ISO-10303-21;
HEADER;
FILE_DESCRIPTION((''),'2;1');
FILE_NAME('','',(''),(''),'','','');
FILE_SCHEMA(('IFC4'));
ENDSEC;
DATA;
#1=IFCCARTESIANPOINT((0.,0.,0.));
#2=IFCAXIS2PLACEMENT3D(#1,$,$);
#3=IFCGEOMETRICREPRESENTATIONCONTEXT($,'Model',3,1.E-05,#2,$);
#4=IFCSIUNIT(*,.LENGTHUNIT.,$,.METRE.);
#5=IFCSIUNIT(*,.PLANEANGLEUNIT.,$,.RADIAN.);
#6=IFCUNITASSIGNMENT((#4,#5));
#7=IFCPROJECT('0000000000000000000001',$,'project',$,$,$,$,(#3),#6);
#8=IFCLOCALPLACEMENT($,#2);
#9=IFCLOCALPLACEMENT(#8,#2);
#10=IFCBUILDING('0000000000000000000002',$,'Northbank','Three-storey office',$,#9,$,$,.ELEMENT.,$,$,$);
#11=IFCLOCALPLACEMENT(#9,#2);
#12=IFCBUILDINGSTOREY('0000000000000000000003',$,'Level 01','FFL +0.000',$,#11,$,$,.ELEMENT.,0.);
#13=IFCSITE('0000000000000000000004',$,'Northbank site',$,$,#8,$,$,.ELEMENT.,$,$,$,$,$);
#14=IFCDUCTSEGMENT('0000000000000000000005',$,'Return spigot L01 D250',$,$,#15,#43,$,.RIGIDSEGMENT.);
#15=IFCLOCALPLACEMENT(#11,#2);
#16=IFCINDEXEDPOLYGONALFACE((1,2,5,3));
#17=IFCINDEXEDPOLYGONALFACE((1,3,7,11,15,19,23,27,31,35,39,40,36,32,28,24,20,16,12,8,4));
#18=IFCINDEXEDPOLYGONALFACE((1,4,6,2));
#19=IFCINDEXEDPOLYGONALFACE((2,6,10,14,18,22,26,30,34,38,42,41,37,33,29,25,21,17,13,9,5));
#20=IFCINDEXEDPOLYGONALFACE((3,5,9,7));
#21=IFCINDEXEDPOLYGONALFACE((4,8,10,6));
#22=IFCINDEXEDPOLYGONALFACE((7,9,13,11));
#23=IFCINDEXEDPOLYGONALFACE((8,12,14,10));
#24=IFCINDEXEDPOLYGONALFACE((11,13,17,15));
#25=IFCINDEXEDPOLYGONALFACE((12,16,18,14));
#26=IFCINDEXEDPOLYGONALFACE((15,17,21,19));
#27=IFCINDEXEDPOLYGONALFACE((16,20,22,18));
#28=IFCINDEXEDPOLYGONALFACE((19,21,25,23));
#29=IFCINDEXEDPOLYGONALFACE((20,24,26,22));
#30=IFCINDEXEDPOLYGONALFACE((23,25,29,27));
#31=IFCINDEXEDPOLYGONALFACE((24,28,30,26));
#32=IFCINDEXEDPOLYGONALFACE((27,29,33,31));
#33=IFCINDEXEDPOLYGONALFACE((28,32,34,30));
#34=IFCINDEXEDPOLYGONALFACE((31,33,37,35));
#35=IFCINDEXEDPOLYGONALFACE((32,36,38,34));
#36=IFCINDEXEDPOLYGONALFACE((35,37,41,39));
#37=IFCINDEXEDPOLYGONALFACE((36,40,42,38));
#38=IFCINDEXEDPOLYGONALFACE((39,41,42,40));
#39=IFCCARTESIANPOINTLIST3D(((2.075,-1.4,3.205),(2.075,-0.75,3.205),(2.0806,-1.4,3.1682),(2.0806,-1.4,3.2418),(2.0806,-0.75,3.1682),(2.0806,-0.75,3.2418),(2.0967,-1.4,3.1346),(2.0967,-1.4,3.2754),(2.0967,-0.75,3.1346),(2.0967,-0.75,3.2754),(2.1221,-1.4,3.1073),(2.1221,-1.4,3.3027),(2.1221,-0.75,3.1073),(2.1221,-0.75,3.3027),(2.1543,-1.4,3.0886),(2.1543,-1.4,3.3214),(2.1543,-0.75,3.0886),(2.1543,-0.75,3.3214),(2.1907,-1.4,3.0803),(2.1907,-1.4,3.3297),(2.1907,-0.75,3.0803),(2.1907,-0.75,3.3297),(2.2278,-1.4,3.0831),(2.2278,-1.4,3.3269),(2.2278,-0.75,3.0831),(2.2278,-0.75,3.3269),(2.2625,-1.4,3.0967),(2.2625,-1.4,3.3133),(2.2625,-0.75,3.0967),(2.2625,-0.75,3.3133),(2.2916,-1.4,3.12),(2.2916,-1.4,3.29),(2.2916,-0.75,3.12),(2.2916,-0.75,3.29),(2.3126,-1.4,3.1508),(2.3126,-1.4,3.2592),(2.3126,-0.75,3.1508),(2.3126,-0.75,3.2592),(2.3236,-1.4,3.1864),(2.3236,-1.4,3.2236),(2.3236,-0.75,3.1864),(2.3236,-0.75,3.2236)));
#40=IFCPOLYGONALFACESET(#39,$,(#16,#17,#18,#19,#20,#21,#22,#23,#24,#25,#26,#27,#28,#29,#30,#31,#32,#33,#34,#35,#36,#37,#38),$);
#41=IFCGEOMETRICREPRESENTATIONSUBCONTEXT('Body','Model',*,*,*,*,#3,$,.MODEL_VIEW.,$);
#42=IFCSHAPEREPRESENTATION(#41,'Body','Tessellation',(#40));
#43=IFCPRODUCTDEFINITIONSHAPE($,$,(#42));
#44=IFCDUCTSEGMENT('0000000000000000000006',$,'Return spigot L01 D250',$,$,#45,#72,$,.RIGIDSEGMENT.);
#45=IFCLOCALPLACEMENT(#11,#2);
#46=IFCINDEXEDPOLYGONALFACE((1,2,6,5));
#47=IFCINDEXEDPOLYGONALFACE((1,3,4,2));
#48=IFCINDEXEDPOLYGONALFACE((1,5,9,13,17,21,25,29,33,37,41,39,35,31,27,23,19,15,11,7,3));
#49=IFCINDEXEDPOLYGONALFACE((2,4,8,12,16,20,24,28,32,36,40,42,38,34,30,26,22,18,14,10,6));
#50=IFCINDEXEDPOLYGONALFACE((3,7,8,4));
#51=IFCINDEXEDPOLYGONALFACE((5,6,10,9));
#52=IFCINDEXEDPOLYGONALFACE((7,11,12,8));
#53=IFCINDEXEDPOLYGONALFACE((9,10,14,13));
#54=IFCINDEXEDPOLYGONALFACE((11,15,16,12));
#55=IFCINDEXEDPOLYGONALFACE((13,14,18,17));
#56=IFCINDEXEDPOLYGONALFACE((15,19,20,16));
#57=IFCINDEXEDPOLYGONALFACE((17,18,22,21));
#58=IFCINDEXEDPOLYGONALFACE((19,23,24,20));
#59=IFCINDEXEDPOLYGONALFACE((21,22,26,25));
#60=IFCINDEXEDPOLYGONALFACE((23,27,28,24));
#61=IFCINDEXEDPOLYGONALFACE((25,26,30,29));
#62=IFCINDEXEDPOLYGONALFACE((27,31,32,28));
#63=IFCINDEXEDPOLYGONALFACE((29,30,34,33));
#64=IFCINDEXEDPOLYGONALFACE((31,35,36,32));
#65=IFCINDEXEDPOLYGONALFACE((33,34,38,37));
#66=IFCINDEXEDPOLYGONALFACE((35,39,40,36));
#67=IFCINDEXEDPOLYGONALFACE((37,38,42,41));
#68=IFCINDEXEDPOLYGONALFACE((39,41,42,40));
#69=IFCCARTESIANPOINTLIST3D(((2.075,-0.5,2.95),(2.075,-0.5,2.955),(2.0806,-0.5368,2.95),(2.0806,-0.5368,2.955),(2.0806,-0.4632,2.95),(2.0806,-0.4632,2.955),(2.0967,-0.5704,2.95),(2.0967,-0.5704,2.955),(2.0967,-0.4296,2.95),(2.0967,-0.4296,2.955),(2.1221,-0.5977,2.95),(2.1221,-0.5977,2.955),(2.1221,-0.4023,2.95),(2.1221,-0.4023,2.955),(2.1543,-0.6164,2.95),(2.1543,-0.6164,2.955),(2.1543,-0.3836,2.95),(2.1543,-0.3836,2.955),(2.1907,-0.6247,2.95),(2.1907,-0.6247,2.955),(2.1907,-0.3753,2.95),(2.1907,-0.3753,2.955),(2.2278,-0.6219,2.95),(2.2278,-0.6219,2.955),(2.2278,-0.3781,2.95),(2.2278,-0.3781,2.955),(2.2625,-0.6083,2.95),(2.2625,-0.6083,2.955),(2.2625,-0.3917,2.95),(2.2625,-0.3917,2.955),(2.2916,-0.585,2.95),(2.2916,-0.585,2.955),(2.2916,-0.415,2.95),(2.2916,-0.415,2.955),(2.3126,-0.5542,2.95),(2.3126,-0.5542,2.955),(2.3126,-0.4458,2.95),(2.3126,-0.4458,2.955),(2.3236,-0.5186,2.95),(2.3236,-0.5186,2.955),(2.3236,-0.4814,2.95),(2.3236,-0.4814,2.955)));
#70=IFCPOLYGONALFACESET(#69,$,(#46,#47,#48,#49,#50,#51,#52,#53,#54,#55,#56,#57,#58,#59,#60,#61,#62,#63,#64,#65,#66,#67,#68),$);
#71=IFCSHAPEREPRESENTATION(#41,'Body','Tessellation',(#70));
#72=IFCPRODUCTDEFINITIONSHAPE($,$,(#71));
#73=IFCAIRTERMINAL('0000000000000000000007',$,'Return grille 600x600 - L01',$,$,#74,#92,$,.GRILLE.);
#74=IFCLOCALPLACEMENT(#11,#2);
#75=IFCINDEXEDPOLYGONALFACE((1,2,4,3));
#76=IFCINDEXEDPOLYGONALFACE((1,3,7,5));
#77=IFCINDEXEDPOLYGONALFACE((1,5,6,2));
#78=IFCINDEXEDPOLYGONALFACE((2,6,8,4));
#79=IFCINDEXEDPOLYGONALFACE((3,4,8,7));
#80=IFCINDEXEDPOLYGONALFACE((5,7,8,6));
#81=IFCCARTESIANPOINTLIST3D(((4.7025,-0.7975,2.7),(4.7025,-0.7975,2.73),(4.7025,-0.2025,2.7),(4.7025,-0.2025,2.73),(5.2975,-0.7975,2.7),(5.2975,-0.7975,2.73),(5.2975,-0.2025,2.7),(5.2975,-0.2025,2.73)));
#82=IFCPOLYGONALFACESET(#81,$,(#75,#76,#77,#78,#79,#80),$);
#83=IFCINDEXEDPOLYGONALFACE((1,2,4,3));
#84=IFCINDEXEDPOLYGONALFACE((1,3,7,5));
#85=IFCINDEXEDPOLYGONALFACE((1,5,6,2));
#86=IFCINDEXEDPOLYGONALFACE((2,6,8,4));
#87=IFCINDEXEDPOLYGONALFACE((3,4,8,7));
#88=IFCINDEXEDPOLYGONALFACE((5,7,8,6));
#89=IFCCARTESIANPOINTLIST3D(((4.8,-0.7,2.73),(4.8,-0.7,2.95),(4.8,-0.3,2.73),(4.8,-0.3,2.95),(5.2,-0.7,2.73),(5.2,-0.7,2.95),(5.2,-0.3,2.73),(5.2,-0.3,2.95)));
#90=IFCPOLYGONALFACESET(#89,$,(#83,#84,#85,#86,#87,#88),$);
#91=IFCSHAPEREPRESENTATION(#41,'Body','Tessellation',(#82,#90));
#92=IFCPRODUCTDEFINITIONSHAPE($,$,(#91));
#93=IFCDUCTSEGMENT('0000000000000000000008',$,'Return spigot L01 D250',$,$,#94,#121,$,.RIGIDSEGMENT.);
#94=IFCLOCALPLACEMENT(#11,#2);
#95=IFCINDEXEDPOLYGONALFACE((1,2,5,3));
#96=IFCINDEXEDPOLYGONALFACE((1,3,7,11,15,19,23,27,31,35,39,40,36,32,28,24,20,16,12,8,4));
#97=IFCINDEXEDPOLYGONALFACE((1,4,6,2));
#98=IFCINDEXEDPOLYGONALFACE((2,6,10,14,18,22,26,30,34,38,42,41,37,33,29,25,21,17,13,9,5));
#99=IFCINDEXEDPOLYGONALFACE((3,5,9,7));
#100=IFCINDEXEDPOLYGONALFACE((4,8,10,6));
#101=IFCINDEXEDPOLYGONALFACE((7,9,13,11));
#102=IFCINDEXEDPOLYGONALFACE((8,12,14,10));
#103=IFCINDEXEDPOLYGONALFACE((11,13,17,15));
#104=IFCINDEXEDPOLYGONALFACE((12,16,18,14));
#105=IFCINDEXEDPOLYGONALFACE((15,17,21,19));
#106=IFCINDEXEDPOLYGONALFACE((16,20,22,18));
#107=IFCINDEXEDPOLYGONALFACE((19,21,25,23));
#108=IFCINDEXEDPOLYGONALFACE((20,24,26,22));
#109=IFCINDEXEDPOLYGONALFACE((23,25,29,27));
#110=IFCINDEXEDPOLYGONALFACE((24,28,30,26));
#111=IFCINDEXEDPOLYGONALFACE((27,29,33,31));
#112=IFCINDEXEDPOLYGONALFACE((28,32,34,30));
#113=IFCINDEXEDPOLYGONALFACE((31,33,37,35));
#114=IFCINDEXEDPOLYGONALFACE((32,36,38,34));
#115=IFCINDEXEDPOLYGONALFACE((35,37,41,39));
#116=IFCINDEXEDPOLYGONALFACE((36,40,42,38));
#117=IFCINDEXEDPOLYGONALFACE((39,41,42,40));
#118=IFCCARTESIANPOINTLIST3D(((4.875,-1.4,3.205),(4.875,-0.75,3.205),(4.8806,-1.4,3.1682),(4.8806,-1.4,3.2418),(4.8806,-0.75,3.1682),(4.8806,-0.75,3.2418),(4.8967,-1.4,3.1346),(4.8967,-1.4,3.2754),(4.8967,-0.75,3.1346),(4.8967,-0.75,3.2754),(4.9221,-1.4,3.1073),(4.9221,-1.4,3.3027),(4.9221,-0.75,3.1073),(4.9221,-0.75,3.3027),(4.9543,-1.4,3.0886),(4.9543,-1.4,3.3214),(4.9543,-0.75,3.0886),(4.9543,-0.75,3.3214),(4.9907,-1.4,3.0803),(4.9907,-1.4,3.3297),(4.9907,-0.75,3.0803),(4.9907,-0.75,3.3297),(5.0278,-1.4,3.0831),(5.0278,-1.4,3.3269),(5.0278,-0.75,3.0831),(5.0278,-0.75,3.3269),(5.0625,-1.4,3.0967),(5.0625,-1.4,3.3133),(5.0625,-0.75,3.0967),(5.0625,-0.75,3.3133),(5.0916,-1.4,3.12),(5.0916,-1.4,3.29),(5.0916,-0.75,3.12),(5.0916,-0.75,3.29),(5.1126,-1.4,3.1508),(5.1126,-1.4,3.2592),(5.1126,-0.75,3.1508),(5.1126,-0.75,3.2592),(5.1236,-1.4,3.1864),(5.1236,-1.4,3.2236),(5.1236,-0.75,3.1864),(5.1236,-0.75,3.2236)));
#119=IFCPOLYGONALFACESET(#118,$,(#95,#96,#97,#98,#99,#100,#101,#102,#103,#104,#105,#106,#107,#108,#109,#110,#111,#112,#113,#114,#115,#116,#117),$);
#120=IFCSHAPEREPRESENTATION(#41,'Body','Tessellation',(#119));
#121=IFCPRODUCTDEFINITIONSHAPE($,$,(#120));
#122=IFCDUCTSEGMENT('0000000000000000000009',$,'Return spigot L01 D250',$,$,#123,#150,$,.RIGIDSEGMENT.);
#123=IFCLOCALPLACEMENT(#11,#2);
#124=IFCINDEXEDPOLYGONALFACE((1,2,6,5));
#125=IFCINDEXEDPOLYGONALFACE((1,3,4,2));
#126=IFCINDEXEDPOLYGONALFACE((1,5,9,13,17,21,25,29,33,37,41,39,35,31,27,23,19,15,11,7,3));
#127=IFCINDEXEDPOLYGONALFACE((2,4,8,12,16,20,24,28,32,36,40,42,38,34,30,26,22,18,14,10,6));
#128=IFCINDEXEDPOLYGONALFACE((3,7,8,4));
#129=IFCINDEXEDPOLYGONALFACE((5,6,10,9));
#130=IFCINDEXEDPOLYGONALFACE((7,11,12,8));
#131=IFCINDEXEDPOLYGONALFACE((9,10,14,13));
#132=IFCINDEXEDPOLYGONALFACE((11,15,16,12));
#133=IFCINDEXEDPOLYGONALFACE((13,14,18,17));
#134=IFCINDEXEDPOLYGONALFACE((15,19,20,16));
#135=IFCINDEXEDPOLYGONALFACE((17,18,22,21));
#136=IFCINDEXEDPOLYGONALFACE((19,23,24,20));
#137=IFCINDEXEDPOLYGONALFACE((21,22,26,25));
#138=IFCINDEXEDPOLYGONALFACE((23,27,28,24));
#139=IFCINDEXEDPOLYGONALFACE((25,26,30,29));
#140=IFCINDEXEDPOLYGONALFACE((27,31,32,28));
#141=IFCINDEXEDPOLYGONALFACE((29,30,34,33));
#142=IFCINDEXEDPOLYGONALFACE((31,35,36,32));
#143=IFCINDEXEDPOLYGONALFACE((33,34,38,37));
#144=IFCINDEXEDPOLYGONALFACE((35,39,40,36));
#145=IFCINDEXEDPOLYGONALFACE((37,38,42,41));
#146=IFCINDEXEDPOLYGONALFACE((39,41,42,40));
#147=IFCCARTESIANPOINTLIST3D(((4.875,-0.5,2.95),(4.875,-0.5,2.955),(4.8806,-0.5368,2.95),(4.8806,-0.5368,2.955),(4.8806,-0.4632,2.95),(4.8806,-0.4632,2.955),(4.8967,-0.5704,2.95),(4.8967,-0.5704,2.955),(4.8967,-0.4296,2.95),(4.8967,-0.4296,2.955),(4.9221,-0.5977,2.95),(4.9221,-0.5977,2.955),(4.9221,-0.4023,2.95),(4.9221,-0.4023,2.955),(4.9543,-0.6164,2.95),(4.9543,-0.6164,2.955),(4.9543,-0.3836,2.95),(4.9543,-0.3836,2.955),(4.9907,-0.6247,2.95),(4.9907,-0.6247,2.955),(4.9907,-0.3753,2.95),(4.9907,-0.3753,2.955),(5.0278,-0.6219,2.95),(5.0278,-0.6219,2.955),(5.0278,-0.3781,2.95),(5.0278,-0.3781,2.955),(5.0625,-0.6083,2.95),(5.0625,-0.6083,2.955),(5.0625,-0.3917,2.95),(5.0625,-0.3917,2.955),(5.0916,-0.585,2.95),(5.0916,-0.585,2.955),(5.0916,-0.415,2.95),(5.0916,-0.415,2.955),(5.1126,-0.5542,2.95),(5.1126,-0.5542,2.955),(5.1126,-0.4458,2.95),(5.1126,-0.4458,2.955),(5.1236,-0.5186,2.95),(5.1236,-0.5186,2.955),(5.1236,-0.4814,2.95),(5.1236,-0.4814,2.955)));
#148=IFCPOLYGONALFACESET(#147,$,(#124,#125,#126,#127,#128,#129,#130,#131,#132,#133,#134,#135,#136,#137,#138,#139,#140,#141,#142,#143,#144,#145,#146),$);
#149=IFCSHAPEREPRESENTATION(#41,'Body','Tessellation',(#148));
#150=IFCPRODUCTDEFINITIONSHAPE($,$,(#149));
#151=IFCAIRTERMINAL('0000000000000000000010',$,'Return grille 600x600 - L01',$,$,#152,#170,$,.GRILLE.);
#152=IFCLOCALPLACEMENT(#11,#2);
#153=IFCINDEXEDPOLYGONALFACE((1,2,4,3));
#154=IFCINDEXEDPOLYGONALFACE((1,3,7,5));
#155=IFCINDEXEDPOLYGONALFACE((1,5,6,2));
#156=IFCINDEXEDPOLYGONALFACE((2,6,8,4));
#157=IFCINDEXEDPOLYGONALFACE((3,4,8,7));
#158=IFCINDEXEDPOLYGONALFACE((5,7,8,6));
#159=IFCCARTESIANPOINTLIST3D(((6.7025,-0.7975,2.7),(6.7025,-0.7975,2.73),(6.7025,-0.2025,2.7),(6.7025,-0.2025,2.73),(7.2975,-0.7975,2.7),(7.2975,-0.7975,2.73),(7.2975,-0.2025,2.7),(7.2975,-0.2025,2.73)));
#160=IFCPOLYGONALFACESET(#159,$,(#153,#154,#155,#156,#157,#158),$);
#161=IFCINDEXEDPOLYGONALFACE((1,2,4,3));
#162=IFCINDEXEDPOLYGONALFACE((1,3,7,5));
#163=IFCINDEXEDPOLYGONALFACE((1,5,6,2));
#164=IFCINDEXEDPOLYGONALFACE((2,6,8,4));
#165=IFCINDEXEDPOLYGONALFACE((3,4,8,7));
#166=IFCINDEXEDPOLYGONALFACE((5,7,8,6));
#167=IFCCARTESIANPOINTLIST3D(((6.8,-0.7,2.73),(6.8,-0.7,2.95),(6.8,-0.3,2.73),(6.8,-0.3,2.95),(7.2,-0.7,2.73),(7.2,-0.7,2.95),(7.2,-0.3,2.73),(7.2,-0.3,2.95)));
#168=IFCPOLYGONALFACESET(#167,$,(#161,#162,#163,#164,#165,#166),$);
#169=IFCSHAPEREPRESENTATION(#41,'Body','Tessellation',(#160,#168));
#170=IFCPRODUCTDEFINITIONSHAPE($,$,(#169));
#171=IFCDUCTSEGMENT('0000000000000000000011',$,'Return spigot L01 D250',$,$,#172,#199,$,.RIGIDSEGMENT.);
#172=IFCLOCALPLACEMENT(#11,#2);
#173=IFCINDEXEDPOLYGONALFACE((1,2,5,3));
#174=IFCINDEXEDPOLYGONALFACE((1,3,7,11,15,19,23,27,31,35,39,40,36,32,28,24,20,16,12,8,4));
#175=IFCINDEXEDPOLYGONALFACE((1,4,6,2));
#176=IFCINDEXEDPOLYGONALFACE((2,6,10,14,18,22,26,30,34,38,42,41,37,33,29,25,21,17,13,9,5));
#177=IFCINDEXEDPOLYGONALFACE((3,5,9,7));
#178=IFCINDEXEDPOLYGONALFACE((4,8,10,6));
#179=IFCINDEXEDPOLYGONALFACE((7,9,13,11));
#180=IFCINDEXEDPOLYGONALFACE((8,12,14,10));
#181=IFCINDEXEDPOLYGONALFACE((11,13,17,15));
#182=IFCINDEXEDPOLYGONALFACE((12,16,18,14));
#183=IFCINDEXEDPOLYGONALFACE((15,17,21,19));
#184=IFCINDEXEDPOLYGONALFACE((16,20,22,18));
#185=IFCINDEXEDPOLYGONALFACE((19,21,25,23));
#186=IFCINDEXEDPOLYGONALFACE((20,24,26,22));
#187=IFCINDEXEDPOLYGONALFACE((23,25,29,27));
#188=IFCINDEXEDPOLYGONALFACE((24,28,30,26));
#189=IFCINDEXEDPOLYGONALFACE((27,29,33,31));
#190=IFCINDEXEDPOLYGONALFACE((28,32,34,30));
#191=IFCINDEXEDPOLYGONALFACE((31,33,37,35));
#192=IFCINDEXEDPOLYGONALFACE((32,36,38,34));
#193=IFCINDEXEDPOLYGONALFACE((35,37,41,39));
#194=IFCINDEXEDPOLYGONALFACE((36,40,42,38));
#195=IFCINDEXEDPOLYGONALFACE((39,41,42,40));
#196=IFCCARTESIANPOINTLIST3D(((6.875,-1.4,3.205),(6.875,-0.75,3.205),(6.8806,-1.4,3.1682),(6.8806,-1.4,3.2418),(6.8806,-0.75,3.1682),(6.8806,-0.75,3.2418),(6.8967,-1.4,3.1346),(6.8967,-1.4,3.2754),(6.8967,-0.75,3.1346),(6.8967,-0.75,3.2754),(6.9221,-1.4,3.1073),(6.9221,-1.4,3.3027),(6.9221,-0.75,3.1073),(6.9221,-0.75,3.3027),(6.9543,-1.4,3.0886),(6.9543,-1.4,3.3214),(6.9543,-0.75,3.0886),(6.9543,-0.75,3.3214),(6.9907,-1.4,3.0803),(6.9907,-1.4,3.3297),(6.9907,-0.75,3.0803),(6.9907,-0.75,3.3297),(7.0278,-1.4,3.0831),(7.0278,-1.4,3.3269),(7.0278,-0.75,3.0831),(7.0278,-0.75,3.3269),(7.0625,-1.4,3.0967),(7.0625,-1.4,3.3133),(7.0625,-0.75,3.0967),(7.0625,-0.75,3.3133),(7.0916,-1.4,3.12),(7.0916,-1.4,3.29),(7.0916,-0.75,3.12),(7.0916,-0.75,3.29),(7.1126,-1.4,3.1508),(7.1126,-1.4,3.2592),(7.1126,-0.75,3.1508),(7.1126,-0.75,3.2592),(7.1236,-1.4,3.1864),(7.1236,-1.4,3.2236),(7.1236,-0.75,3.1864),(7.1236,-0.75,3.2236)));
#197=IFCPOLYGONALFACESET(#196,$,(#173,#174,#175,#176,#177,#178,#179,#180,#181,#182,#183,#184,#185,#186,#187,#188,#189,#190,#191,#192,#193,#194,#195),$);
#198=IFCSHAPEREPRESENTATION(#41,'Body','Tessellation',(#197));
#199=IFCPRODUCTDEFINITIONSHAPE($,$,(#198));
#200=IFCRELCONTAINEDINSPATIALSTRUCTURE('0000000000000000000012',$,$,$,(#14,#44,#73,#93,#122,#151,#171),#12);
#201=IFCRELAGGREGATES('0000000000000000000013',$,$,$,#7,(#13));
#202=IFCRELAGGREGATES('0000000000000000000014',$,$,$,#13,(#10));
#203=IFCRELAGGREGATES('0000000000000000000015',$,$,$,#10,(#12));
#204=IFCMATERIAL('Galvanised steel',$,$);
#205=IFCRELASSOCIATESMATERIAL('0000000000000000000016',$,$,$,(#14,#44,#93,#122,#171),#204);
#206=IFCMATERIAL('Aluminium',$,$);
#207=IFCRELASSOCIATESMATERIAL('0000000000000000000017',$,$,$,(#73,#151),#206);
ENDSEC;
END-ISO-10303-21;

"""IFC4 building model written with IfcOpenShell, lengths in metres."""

from ifc_helpers import new_model, si_unit, frame, origin, place, context, subcontext, project, spatial, rectangle, circle, extrude, material, element, save


model = new_model("IFC4")

# Units and contexts
model_context = context("Model", 3, precision=1e-05, world=origin())
body_context = subcontext(model_context, "Body", "Model", "MODEL_VIEW")
ifc_project = project(units=[si_unit("LENGTHUNIT", "METRE"), si_unit("PLANEANGLEUNIT", "RADIAN")], contexts=[model_context])

# Site, building, storey
site_placement = place(None, origin())
site = spatial("IfcSite", under=ifc_project, at=site_placement, Name="Northbank site", CompositionType="ELEMENT")
building_placement = place(site_placement, origin())
building = spatial("IfcBuilding", under=site, at=building_placement, Name="Northbank", Description="Three-storey office", CompositionType="ELEMENT")
storey_placement = place(building_placement, origin())
storey = spatial("IfcBuildingStorey", under=building, at=storey_placement, Name="Level 01", Description="FFL +0.000", CompositionType="ELEMENT", Elevation=0.0)

# Shared definitions
ifc_material_1 = material(Name="Galvanised steel")

# Shared definitions
ifc_material_2 = material(Name="Aluminium")

# Duct segments
duct_segment_1_placement = place(storey_placement, origin())
element("IfcDuctSegment", 1, at=duct_segment_1_placement, inside=storey, material=ifc_material_1, Name="Return spigot L01 D250", PredefinedType="RIGIDSEGMENT", context=body_context, shape_type="SweptSolid", body=[
    extrude(circle(Radius=0.125), frame((2.2, -1.4, 3.205), z_axis=(0.0, 1.0, 0.0), x_axis=(-1.0, 0.0, 0.0)), (0.0, 0.0, 1.0), 0.65),
])
duct_segment_2_placement = place(storey_placement, origin())
element("IfcDuctSegment", 2, at=duct_segment_2_placement, inside=storey, material=ifc_material_1, Name="Return spigot L01 D250", PredefinedType="RIGIDSEGMENT", context=body_context, shape_type="SweptSolid", body=[
    extrude(circle(Radius=0.125), frame((2.2, -0.5, 2.955), z_axis=(0.0, 0.0, -1.0), x_axis=(-1.0, 0.0, 0.0)), (0.0, 0.0, 1.0), 0.005),
])

# Air terminal
air_terminal_1_placement = place(storey_placement, origin())
element("IfcAirTerminal", 3, at=air_terminal_1_placement, inside=storey, material=ifc_material_2, Name="Return grille 600x600 - L01", PredefinedType="GRILLE", context=body_context, shape_type="SweptSolid", body=[
    extrude(rectangle(XDim=0.595, YDim=0.595), frame((5.0, -0.5, 2.7)), (0.0, 0.0, 1.0), 0.03),
    extrude(rectangle(XDim=0.4, YDim=0.4), frame((5.0, -0.5, 2.73)), (0.0, 0.0, 1.0), 0.22),
])

# Duct segments
duct_segment_3_placement = place(storey_placement, origin())
element("IfcDuctSegment", 4, at=duct_segment_3_placement, inside=storey, material=ifc_material_1, Name="Return spigot L01 D250", PredefinedType="RIGIDSEGMENT", context=body_context, shape_type="SweptSolid", body=[
    extrude(circle(Radius=0.125), frame((5.0, -1.4, 3.205), z_axis=(0.0, 1.0, 0.0), x_axis=(-1.0, 0.0, 0.0)), (0.0, 0.0, 1.0), 0.65),
])
duct_segment_4_placement = place(storey_placement, origin())
element("IfcDuctSegment", 5, at=duct_segment_4_placement, inside=storey, material=ifc_material_1, Name="Return spigot L01 D250", PredefinedType="RIGIDSEGMENT", context=body_context, shape_type="SweptSolid", body=[
    extrude(circle(Radius=0.125), frame((5.0, -0.5, 2.955), z_axis=(0.0, 0.0, -1.0), x_axis=(-1.0, 0.0, 0.0)), (0.0, 0.0, 1.0), 0.005),
])

# Air terminal
air_terminal_2_placement = place(storey_placement, origin())
element("IfcAirTerminal", 6, at=air_terminal_2_placement, inside=storey, material=ifc_material_2, Name="Return grille 600x600 - L01", PredefinedType="GRILLE", context=body_context, shape_type="SweptSolid", body=[
    extrude(rectangle(XDim=0.595, YDim=0.595), frame((7.0, -0.5, 2.7)), (0.0, 0.0, 1.0), 0.03),
    extrude(rectangle(XDim=0.4, YDim=0.4), frame((7.0, -0.5, 2.73)), (0.0, 0.0, 1.0), 0.22),
])

# Duct segment
duct_segment_5_placement = place(storey_placement, origin())
element("IfcDuctSegment", 7, at=duct_segment_5_placement, inside=storey, material=ifc_material_1, Name="Return spigot L01 D250", PredefinedType="RIGIDSEGMENT", context=body_context, shape_type="SweptSolid", body=[
    extrude(circle(Radius=0.125), frame((7.0, -1.4, 3.205), z_axis=(0.0, 1.0, 0.0), x_axis=(-1.0, 0.0, 0.0)), (0.0, 0.0, 1.0), 0.65),
])

save(model, "model.ifc")
